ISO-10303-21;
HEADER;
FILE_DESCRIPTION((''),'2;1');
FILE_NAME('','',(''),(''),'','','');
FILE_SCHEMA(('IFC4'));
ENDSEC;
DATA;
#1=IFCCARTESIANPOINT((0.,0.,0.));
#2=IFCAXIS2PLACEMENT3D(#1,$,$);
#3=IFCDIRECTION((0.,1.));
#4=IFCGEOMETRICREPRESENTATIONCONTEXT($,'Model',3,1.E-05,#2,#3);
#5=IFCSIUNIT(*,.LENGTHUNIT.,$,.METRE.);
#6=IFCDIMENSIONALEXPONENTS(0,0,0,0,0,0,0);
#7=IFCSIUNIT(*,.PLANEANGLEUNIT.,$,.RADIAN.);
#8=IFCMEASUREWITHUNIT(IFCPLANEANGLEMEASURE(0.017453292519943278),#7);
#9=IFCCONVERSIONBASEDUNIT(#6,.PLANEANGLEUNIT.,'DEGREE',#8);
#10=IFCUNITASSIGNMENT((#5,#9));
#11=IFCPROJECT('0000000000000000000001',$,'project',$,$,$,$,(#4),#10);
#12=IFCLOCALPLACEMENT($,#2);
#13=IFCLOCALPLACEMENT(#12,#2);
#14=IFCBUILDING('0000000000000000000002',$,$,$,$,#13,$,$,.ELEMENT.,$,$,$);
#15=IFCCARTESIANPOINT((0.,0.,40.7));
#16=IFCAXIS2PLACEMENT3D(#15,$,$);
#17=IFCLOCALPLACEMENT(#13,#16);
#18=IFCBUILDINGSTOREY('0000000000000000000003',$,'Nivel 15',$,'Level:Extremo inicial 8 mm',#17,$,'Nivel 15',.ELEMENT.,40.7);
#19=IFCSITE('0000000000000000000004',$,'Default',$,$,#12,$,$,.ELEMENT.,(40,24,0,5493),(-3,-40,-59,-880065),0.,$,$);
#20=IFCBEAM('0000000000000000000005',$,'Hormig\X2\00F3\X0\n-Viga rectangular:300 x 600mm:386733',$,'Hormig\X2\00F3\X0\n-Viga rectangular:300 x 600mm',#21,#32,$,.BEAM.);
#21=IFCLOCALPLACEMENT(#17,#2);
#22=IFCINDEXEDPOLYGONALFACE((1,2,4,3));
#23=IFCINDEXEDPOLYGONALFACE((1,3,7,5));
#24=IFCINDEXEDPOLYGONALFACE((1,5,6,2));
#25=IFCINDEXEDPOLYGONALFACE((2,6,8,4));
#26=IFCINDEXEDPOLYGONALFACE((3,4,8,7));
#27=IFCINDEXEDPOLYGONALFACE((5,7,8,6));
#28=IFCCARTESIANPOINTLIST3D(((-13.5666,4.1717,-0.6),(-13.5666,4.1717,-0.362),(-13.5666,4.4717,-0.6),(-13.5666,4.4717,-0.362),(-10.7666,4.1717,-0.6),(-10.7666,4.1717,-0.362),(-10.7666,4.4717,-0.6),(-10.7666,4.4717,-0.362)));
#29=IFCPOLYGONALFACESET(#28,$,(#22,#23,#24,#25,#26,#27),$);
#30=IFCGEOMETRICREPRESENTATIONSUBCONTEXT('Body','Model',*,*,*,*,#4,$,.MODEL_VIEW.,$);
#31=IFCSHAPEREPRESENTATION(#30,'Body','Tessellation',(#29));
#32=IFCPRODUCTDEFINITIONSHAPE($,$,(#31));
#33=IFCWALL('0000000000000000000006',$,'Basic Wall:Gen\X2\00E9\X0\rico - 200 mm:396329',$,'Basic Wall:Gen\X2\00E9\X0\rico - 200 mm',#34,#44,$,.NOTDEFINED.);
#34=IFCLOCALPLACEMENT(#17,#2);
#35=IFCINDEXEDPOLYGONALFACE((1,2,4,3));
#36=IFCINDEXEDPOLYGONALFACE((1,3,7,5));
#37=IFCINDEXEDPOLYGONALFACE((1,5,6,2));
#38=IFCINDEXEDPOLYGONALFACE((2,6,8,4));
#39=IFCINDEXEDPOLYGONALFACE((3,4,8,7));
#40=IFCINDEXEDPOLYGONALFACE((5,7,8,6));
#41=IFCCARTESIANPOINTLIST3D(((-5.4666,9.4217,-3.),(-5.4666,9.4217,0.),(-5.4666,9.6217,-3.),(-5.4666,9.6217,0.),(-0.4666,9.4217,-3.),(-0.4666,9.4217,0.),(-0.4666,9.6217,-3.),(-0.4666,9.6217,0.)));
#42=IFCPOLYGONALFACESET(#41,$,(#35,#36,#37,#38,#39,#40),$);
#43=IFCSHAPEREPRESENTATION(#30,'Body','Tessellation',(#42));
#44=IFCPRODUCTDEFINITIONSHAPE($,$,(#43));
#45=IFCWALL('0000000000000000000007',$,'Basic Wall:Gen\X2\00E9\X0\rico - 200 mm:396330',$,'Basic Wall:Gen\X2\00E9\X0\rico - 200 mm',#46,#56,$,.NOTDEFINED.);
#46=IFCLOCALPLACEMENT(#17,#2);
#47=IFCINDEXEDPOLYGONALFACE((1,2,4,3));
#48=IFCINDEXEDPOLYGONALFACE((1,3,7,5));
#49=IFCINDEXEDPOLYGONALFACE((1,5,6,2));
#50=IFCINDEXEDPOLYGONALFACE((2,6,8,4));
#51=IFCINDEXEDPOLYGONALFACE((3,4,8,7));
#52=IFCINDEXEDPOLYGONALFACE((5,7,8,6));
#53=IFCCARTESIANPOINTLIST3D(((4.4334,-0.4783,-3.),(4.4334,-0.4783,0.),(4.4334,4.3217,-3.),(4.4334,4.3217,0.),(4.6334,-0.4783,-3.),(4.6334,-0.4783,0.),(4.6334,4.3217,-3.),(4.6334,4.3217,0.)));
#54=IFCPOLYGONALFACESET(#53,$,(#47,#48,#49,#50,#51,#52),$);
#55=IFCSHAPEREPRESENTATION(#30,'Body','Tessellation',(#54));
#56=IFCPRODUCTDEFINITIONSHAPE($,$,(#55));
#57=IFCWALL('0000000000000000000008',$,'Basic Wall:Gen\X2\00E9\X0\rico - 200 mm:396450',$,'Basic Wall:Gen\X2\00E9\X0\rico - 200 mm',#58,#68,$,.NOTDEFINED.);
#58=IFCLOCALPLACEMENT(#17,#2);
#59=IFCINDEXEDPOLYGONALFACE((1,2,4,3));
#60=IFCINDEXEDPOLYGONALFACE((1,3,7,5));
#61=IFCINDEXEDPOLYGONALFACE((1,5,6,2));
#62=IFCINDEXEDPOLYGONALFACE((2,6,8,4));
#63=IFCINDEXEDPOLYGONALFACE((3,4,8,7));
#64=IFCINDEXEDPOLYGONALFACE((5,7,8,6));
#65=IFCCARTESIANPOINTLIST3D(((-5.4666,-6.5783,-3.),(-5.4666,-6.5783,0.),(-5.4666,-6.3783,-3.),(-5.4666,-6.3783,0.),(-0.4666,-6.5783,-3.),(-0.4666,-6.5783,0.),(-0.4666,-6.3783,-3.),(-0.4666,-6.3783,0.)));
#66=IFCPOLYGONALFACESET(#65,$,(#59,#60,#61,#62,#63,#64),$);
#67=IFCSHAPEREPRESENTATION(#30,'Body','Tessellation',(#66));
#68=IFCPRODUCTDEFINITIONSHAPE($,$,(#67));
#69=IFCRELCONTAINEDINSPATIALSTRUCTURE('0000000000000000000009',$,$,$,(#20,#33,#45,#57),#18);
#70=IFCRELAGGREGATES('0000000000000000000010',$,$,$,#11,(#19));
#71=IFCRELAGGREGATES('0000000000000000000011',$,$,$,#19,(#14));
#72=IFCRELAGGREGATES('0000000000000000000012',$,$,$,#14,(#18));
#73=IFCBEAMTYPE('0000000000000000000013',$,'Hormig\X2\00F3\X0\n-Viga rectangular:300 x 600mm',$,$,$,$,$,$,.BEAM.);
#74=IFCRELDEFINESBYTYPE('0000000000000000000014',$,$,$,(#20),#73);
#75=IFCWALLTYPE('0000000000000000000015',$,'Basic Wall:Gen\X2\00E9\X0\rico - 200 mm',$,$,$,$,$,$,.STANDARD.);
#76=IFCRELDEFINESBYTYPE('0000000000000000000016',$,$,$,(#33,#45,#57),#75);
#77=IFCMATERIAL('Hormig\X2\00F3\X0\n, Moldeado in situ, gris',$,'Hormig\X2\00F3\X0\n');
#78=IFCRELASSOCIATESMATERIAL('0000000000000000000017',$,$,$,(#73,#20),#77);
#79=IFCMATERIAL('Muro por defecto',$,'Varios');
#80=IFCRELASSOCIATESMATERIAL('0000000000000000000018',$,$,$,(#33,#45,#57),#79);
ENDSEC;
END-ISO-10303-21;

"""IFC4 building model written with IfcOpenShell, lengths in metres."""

from ifc_helpers import new_model, entity, si_unit, converted_unit, direction, frame, origin, place, context, subcontext, project, spatial, indexed_curve, outline, extrude, source, transform, mapped, material, type_object, type_shapes, element, save


model = new_model("IFC4")

# Units and contexts
model_context = context("Model", 3, precision=1e-05, world=origin(), true_north=direction((0.0, 1.0)))
body_context = subcontext(model_context, "Body", "Model", "MODEL_VIEW")
ifc_project = project(units=[si_unit("LENGTHUNIT", "METRE"), converted_unit("PLANEANGLEUNIT", "DEGREE", entity("IfcPlaneAngleMeasure", 0.017453292519943278), si_unit("PLANEANGLEUNIT", "RADIAN"), dimensions=[0, 0, 0, 0, 0, 0, 0])], contexts=[model_context])

# Site, building, storey
site_placement = place(None, origin())
site = spatial("IfcSite", under=ifc_project, at=site_placement, Name="Default", CompositionType="ELEMENT", RefLatitude=(40, 24, 0, 5493), RefLongitude=(-3, -40, -59, -880065), RefElevation=0.0)
building_placement = place(site_placement, origin())
building = spatial("IfcBuilding", under=site, at=building_placement, CompositionType="ELEMENT")
storey_placement = place(building_placement, frame((0.0, 0.0, 40.7)))
storey = spatial("IfcBuildingStorey", under=building, at=storey_placement, Name="Nivel 15", ObjectType="Level:Extremo inicial 8 mm", LongName="Nivel 15", CompositionType="ELEMENT", Elevation=40.7)

# Shared definitions
ifc_material_1 = material(Name="Hormigón, Moldeado in situ, gris", Category="Hormigón")

# Beam
beam_type_1 = type_object("IfcBeamType", Name="Hormigón-Viga rectangular:300 x 600mm", PredefinedType="BEAM", material=ifc_material_1)
shared_shape_1 = source(origin(), body_context, "Body", "SweptSolid", [
    extrude(outline(indexed_curve([(-0.119, -0.15), (0.119, -0.15), (0.119, 0.15), (-0.119, 0.15), (-0.119, -0.15)], self_intersect=False)), frame((-10.7666, 4.3217, 40.219), z_axis=(-1.0, 0.0, 0.0), x_axis=(0.0, 0.0, -1.0)), (0.0, 0.0, 1.0), 2.8),
])
type_shapes(beam_type_1, [shared_shape_1])
beam_1_placement = place(storey_placement, frame((0.0, 0.0, -40.7)))
element("IfcBeam", 1, at=beam_1_placement, inside=storey, type_object=beam_type_1, material=ifc_material_1, Name="Hormigón-Viga rectangular:300 x 600mm:386733", ObjectType="Hormigón-Viga rectangular:300 x 600mm", PredefinedType="BEAM", context=body_context, shape_type="MappedRepresentation", body=[
    mapped(shared_shape_1, transform((0.0, 0.0, 0.0), scale=1.0)),
])

# Walls
ifc_material_2 = material(Name="Muro por defecto", Category="Varios")
wall_type = type_object("IfcWallType", Name="Basic Wall:Genérico - 200 mm", PredefinedType="STANDARD")
wall_1_placement = place(storey_placement, frame((-5.4666, 9.5217, -3.0)))
element("IfcWall", 2, at=wall_1_placement, inside=storey, type_object=wall_type, material=ifc_material_2, Name="Basic Wall:Genérico - 200 mm:396329", ObjectType="Basic Wall:Genérico - 200 mm", PredefinedType="NOTDEFINED", context=body_context, shape_type="SweptSolid", body=[
    extrude(outline(indexed_curve([(5.0, 0.1), (0.0, 0.1), (0.0, -0.1), (5.0, -0.1), (5.0, 0.1)], self_intersect=False)), origin(), (0.0, 0.0, 1.0), 3.0),
])
wall_2_placement = place(storey_placement, frame((4.5334, 4.3217, -3.0), z_axis=(0.0, 0.0, 1.0), x_axis=(0.0, -1.0, 0.0)))
element("IfcWall", 3, at=wall_2_placement, inside=storey, type_object=wall_type, material=ifc_material_2, Name="Basic Wall:Genérico - 200 mm:396330", ObjectType="Basic Wall:Genérico - 200 mm", PredefinedType="NOTDEFINED", context=body_context, shape_type="SweptSolid", body=[
    extrude(outline(indexed_curve([(4.8, 0.1), (0.0, 0.1), (0.0, -0.1), (4.8, -0.1), (4.8, 0.1)], self_intersect=False)), origin(), (0.0, 0.0, 1.0), 3.0),
])
wall_3_placement = place(storey_placement, frame((-5.4666, -6.4783, -3.0)))
element("IfcWall", 4, at=wall_3_placement, inside=storey, type_object=wall_type, material=ifc_material_2, Name="Basic Wall:Genérico - 200 mm:396450", ObjectType="Basic Wall:Genérico - 200 mm", PredefinedType="NOTDEFINED", context=body_context, shape_type="SweptSolid", body=[
    extrude(outline(indexed_curve([(5.0, 0.1), (0.0, 0.1), (0.0, -0.1), (5.0, -0.1), (5.0, 0.1)], self_intersect=False)), origin(), (0.0, 0.0, 1.0), 3.0),
])

save(model, "model.ifc")
